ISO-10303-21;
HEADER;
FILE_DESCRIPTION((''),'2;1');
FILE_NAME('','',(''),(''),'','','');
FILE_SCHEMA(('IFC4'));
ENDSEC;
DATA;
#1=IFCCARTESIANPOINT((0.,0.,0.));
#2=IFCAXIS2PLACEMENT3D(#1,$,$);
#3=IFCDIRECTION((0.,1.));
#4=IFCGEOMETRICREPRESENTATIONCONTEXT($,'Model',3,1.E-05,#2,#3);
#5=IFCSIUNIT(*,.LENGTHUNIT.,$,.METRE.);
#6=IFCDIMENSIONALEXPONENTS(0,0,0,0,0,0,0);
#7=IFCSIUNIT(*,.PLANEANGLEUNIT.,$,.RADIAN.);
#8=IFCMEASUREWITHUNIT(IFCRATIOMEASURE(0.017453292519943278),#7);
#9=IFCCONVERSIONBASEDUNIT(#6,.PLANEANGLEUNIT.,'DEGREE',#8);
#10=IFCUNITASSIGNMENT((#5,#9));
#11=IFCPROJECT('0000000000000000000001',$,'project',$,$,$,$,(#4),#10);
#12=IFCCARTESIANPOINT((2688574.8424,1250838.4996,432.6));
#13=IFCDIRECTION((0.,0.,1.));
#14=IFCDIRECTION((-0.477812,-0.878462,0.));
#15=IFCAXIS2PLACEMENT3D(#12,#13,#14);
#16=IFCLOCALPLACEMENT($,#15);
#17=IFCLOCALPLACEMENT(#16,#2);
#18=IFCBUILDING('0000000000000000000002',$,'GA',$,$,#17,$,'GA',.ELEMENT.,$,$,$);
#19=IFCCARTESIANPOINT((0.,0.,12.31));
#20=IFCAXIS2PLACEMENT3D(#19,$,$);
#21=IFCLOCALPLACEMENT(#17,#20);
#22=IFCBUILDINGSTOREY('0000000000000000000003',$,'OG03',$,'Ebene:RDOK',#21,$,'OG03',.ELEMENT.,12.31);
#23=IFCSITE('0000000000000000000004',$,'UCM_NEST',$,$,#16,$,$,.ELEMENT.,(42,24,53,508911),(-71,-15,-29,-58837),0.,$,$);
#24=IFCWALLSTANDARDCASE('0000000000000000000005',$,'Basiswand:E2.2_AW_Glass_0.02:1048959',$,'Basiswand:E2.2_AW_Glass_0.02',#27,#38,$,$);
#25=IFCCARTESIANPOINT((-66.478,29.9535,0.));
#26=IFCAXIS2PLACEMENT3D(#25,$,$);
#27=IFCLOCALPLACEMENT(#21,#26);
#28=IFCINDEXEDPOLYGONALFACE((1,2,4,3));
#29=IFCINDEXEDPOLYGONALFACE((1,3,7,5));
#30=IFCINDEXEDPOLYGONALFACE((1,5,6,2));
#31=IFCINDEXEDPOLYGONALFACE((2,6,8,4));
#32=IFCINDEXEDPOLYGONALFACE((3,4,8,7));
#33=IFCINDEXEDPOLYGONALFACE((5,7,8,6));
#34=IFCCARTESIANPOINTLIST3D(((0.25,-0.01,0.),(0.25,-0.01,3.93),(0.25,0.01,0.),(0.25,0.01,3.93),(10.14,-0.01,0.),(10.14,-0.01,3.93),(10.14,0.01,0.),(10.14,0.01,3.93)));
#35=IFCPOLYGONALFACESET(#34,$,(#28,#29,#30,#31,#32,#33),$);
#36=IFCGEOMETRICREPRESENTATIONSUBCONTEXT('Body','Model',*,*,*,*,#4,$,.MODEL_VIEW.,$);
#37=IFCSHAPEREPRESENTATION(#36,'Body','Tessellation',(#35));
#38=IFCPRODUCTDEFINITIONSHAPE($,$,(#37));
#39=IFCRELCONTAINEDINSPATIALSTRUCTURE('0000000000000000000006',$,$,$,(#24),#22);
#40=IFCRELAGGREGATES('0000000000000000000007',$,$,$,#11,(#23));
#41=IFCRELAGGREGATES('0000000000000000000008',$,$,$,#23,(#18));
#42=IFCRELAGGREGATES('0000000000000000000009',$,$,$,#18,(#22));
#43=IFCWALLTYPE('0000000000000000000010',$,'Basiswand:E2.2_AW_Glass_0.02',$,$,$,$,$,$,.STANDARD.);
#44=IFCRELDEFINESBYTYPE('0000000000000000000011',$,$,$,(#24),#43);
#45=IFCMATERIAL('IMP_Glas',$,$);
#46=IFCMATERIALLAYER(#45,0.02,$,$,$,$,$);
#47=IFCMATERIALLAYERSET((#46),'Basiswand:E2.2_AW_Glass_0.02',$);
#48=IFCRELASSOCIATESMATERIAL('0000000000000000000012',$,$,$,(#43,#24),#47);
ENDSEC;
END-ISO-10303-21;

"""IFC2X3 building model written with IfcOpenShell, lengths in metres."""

from ifc_helpers import new_model, entity, si_unit, converted_unit, direction, frame, frame_2d, origin, place, context, subcontext, project, spatial, rectangle, extrude, material, layer, layer_set, layer_usage, type_object, element, save


model = new_model("IFC2X3")

# Units and contexts
model_context = context("Model", 3, precision=1e-05, world=origin(), true_north=direction((0.0, 1.0)))
body_context = subcontext(model_context, "Body", "Model", "MODEL_VIEW")
ifc_project = project(units=[si_unit("LENGTHUNIT", "METRE"), converted_unit("PLANEANGLEUNIT", "DEGREE", entity("IfcRatioMeasure", 0.017453292519943278), si_unit("PLANEANGLEUNIT", "RADIAN"), dimensions=[0, 0, 0, 0, 0, 0, 0])], contexts=[model_context])

# Site, building, storey
site_placement = place(None, frame((2688574.8424, 1250838.4996, 432.6), z_axis=(0.0, 0.0, 1.0), x_axis=(-0.477812, -0.878462, 0.0)))
site = spatial("IfcSite", under=ifc_project, at=site_placement, Name="UCM_NEST", CompositionType="ELEMENT", RefLatitude=(42, 24, 53, 508911), RefLongitude=(-71, -15, -29, -58837), RefElevation=0.0)
building_placement = place(site_placement, origin())
building = spatial("IfcBuilding", under=site, at=building_placement, Name="GA", LongName="GA", CompositionType="ELEMENT")
storey_placement = place(building_placement, frame((0.0, 0.0, 12.31)))
storey = spatial("IfcBuildingStorey", under=building, at=storey_placement, Name="OG03", ObjectType="Ebene:RDOK", LongName="OG03", CompositionType="ELEMENT", Elevation=12.31)

# Wall
ifc_material_1 = material(Name="IMP_Glas")
ifc_layer_1 = layer(ifc_material_1, 0.02)
ifc_layer_set_1 = layer_set([ifc_layer_1], Name="Basiswand:E2.2_AW_Glass_0.02")
ifc_layer_usage_1 = layer_usage(ifc_layer_set_1, "AXIS2", "NEGATIVE", 0.01)
wall_type_1 = type_object("IfcWallType", Name="Basiswand:E2.2_AW_Glass_0.02", PredefinedType="STANDARD", material=ifc_layer_set_1)
wall_1_placement = place(storey_placement, frame((-66.478, 29.9535, 0.0)))
element("IfcWallStandardCase", 1, at=wall_1_placement, inside=storey, type_object=wall_type_1, material=ifc_layer_usage_1, Name="Basiswand:E2.2_AW_Glass_0.02:1048959", ObjectType="Basiswand:E2.2_AW_Glass_0.02", context=body_context, shape_type="SweptSolid", body=[
    extrude(rectangle(XDim=9.89, YDim=0.02, at=frame_2d((5.195, 0.0), x_axis=(-1.0, 0.0))), origin(), (0.0, 0.0, 1.0), 3.93),
])

save(model, "model.ifc")
